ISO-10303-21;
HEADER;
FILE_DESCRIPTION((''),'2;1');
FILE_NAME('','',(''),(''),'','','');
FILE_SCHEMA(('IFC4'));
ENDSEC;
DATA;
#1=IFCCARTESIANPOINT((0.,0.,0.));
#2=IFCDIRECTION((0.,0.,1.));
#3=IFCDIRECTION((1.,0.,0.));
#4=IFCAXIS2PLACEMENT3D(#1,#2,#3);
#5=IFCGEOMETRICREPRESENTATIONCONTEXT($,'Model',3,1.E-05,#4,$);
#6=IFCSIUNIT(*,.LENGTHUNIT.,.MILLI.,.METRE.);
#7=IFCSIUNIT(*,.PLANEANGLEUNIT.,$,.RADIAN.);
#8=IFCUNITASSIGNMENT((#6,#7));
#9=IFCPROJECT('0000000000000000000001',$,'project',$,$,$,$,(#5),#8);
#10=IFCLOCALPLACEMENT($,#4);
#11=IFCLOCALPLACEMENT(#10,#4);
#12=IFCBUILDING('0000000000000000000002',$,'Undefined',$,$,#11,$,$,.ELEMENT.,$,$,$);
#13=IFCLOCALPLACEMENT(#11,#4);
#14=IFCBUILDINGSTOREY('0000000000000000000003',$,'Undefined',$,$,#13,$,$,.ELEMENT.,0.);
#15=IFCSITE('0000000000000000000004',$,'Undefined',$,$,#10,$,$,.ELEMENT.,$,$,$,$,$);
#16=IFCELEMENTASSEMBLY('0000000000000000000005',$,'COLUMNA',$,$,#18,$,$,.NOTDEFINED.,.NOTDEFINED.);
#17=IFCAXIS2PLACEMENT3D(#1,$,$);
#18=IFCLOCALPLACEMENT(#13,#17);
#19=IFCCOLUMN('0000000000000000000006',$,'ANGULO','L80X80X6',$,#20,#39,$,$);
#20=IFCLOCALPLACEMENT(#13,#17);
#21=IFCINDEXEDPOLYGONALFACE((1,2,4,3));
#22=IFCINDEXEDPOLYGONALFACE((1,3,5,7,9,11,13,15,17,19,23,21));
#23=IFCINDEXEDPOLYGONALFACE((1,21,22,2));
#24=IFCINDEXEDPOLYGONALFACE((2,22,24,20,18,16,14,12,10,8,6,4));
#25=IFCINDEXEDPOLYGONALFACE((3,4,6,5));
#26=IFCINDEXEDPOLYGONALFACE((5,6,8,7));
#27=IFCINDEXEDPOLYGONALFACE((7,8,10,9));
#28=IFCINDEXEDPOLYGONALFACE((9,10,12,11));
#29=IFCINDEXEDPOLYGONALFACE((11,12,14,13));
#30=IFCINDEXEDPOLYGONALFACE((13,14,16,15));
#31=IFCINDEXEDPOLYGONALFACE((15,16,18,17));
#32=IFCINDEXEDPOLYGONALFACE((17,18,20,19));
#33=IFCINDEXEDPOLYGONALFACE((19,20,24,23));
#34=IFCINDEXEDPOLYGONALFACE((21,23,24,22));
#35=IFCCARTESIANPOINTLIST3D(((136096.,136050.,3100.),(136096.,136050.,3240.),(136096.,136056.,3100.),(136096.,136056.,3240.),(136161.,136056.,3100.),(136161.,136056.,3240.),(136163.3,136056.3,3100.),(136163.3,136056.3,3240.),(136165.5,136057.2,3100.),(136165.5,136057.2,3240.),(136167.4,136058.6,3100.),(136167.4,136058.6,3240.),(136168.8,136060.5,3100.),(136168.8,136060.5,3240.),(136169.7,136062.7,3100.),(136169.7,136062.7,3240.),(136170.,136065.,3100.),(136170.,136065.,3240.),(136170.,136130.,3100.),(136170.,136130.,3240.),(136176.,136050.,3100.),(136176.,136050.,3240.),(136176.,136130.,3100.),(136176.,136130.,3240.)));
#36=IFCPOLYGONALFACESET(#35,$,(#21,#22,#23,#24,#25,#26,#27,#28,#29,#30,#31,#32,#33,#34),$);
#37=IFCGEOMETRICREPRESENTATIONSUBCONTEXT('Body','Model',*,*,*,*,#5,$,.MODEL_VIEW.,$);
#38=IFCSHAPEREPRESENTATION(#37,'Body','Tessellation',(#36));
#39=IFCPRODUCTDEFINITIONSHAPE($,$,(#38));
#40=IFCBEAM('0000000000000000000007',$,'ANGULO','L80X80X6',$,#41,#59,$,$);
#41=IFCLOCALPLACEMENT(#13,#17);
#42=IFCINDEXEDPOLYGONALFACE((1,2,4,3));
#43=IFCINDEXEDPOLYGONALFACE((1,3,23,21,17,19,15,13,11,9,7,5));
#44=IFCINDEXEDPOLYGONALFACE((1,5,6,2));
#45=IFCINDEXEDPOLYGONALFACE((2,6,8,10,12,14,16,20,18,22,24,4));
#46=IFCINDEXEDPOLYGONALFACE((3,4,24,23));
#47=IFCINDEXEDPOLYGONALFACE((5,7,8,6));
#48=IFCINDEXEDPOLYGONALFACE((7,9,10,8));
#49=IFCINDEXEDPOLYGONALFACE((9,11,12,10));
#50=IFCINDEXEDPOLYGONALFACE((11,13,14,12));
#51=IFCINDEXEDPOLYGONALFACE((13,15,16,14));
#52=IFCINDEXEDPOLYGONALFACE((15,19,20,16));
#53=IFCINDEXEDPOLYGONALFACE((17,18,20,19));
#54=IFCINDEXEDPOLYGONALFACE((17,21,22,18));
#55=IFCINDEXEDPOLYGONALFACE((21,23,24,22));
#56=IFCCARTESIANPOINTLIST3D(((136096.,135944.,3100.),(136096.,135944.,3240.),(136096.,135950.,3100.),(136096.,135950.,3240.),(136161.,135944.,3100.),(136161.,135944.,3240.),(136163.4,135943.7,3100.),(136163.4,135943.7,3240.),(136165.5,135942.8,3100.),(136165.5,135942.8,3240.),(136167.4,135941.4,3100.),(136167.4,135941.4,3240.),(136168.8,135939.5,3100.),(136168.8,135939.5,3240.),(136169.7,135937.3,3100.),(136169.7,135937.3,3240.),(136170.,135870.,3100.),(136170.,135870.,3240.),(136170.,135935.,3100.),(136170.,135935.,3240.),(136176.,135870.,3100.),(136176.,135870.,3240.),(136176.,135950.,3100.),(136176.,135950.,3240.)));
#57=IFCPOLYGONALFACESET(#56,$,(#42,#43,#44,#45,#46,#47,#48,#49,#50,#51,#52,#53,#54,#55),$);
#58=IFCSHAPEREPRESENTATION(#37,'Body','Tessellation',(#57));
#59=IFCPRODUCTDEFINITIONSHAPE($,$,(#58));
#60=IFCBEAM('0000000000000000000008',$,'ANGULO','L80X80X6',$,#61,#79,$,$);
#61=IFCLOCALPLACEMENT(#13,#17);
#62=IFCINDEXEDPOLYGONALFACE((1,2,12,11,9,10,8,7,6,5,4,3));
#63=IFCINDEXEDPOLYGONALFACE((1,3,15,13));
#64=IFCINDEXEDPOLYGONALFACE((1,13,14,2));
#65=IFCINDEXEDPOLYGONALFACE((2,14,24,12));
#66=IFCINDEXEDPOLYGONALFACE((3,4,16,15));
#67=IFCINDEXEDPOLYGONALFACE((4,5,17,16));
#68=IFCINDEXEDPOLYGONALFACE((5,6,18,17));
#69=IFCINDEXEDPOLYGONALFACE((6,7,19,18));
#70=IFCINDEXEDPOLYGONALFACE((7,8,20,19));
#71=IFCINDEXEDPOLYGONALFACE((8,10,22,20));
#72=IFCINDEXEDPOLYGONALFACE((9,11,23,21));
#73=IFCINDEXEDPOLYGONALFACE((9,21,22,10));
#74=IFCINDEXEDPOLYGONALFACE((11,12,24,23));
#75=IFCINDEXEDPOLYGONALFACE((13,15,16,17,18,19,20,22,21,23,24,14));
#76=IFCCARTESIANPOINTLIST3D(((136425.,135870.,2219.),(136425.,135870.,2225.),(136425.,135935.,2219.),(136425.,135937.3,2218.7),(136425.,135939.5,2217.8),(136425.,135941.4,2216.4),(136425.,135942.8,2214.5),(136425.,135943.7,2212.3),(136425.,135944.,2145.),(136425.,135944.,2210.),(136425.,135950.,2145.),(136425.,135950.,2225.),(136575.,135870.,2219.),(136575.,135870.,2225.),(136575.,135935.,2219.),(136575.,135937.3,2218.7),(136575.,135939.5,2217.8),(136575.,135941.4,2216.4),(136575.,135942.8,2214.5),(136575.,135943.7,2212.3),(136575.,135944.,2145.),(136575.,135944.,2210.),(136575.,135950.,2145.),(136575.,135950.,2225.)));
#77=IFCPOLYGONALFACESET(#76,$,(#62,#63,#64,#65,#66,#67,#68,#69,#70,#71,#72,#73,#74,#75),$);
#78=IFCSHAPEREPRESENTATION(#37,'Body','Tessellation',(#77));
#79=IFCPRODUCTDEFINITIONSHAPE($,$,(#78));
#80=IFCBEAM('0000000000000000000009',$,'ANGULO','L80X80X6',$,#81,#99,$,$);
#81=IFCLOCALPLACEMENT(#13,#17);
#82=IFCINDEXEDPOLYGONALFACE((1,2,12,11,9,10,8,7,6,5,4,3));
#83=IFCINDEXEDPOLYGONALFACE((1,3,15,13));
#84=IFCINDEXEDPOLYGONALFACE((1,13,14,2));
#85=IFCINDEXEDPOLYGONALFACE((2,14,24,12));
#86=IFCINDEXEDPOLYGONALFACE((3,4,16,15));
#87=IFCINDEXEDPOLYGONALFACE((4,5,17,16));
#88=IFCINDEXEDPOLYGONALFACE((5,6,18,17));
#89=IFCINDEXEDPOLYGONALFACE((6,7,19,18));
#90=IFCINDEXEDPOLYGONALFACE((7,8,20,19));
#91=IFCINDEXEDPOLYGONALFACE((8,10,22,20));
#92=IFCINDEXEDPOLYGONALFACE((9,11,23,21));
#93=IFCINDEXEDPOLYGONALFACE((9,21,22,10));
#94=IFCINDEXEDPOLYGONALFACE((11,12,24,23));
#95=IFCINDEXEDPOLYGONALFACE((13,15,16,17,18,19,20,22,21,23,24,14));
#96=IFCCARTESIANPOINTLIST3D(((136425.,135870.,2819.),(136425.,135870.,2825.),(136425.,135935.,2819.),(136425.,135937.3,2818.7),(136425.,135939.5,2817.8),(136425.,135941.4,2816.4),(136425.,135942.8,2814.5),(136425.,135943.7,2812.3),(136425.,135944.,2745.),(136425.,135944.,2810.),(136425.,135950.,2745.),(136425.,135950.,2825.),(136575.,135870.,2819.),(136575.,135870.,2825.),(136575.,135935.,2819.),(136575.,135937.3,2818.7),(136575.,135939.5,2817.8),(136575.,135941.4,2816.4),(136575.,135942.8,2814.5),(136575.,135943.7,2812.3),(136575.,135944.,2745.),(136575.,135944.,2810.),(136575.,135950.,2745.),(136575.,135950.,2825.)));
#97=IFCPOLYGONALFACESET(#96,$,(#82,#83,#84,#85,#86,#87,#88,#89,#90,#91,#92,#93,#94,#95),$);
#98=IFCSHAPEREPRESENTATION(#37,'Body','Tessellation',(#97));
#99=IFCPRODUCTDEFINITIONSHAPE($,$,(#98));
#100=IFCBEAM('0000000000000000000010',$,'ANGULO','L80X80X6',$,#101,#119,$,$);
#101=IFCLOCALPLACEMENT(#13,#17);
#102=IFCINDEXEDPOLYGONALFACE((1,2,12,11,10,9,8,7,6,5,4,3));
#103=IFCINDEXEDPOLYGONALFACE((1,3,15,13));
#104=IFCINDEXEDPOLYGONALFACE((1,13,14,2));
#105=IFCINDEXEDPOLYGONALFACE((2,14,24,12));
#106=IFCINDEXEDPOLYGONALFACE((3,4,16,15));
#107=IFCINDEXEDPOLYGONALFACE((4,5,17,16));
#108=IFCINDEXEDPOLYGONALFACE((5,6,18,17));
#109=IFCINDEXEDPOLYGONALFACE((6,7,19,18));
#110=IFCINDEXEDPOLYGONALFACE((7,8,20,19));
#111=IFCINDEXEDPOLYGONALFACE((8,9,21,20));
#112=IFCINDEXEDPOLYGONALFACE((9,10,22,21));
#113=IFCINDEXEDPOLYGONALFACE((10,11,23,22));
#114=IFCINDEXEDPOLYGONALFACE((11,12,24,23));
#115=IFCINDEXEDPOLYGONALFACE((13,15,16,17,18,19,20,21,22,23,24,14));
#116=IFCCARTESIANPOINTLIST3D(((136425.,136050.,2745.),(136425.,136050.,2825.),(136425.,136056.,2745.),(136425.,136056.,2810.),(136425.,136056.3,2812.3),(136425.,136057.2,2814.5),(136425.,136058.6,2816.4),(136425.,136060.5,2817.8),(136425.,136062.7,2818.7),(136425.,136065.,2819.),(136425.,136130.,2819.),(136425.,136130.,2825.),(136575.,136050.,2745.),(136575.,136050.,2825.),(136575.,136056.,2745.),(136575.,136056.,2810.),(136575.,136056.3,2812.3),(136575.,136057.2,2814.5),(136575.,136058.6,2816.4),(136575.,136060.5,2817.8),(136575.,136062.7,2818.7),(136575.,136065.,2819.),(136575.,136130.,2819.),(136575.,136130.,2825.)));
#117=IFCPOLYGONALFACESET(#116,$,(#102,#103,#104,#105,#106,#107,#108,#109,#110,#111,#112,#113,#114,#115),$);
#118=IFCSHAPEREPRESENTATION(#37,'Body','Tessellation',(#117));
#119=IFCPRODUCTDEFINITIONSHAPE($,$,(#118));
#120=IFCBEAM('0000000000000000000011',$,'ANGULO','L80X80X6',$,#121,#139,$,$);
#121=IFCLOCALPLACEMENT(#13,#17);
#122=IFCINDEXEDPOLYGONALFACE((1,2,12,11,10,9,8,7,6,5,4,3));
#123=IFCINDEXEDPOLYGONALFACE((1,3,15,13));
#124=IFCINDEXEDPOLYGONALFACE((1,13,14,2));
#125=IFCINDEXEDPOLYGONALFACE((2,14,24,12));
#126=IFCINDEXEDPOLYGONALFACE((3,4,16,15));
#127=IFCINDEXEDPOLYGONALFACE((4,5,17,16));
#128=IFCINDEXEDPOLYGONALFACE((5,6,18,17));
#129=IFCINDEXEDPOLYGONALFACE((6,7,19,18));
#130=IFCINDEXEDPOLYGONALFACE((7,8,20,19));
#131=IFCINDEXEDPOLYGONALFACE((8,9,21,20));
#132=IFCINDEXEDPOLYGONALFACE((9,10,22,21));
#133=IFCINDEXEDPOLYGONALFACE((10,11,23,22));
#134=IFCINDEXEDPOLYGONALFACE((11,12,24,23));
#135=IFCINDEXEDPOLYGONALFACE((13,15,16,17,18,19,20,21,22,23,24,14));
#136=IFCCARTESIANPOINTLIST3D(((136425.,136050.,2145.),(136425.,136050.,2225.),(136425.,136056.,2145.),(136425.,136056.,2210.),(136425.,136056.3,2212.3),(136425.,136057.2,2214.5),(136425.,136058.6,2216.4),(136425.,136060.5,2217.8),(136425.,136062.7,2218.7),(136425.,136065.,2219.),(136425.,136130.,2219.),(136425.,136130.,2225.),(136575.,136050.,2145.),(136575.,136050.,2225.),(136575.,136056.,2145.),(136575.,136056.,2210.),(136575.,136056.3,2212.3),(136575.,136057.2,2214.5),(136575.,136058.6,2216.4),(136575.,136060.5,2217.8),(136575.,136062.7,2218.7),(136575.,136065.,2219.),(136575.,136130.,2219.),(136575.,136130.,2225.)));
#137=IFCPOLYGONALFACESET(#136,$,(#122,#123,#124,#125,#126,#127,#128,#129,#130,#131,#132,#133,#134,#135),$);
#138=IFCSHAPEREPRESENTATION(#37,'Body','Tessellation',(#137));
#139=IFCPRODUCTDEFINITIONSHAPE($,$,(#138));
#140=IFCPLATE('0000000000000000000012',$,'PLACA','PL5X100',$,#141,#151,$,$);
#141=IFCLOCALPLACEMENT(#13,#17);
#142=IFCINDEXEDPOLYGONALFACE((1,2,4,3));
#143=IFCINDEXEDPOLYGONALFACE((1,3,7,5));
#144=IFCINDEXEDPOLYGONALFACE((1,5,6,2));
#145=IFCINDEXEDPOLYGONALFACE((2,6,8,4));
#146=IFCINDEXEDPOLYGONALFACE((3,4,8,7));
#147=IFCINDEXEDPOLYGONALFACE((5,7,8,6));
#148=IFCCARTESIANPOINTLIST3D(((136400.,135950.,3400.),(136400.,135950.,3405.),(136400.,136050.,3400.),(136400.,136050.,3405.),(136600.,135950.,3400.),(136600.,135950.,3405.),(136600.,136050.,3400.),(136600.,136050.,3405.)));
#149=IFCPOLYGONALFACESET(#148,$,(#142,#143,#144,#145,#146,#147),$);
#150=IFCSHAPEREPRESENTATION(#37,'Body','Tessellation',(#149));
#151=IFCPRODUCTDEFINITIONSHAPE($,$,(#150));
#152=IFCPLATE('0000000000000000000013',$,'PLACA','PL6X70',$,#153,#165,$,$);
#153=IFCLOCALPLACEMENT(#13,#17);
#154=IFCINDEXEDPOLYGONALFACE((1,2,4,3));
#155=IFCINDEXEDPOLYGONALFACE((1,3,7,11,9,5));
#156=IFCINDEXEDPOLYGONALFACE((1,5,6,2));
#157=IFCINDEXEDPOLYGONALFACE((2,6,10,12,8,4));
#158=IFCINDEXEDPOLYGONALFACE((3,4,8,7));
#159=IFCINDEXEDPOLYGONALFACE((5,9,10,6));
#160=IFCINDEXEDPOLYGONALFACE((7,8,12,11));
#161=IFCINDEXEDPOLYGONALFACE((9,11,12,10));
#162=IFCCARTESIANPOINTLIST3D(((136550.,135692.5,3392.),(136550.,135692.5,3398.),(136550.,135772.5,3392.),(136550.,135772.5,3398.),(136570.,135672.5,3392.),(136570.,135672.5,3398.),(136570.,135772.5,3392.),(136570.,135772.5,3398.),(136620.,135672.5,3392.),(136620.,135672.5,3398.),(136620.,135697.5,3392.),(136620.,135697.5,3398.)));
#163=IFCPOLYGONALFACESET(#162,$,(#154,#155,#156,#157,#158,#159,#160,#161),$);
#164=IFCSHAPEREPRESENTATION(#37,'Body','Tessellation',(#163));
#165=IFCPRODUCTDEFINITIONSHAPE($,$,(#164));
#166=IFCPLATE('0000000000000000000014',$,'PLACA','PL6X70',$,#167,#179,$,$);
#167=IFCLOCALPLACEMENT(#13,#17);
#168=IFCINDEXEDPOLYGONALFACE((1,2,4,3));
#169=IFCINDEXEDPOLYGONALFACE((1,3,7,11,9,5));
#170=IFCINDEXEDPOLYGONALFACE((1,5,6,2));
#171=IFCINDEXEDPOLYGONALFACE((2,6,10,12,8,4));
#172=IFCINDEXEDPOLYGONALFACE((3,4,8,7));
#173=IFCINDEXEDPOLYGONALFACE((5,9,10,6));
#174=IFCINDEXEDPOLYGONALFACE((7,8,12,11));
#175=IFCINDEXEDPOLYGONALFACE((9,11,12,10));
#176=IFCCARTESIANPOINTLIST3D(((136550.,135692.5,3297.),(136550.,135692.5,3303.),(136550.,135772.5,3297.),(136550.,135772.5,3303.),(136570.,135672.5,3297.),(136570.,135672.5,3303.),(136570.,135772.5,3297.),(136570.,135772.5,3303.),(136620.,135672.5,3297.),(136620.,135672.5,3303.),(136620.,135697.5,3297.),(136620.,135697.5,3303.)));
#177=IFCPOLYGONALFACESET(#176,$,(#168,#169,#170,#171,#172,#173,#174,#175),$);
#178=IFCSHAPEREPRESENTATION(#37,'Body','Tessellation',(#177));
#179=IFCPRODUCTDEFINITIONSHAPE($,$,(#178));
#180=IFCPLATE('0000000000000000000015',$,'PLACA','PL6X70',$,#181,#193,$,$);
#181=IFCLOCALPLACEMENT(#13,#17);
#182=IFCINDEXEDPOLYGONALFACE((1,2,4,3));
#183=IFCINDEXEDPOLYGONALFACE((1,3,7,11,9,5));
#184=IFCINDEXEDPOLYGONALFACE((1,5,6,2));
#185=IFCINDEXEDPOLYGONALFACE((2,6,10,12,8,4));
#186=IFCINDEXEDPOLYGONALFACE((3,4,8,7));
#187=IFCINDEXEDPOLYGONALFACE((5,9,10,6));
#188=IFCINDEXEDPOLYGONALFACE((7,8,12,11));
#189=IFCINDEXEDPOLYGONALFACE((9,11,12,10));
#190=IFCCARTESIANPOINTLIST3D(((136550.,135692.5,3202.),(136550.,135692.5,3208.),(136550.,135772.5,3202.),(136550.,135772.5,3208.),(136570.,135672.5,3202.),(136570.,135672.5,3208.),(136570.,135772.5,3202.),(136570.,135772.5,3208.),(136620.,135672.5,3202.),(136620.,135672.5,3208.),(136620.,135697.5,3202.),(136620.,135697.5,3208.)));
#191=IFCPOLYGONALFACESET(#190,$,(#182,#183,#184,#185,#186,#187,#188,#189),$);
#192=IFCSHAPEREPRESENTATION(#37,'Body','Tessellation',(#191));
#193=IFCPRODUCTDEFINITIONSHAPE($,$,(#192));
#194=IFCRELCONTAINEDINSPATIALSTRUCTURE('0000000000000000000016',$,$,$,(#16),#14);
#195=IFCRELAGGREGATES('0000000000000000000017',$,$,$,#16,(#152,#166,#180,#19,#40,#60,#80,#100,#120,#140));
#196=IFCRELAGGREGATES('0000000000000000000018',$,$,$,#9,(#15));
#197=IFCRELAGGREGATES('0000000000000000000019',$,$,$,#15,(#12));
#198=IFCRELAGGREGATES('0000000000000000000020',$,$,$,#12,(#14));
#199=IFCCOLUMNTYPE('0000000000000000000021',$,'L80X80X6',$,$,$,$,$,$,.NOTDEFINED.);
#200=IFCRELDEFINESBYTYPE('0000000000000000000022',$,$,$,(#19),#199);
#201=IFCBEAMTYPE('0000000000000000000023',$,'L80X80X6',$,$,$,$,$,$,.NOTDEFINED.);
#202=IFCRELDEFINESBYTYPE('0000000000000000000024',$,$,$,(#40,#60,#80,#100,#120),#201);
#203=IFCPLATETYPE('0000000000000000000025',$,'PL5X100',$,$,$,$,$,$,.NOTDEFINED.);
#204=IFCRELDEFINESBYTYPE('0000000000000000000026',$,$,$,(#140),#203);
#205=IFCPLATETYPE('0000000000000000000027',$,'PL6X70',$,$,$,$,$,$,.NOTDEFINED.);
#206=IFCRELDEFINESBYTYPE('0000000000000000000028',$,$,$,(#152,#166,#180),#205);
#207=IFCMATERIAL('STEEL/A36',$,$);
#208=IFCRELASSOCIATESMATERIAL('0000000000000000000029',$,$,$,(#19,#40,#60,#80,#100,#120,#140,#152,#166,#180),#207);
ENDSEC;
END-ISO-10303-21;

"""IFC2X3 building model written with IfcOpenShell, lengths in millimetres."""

from ifc_helpers import new_model, si_unit, frame, origin_with_axes, origin_2d_with_axis, place, context, subcontext, project, spatial, polyline, l_section, outline, extrude, material, type_object, element, aggregate, save


model = new_model("IFC2X3")

# Units and contexts
model_context = context("Model", 3, precision=1e-05, world=origin_with_axes())
body_context = subcontext(model_context, "Body", "Model", "MODEL_VIEW")
ifc_project = project(units=[si_unit("LENGTHUNIT", "METRE", prefix="MILLI"), si_unit("PLANEANGLEUNIT", "RADIAN")], contexts=[model_context])

# Site, building, storey
site_placement = place(None, origin_with_axes())
site = spatial("IfcSite", under=ifc_project, at=site_placement, Name="Undefined", CompositionType="ELEMENT")
building_placement = place(site_placement, origin_with_axes())
building = spatial("IfcBuilding", under=site, at=building_placement, Name="Undefined", CompositionType="ELEMENT")
storey_placement = place(building_placement, origin_with_axes())
storey = spatial("IfcBuildingStorey", under=building, at=storey_placement, Name="Undefined", CompositionType="ELEMENT", Elevation=0.0)

# Element assembly, column, beams
assembly_1_placement = place(storey_placement, origin_with_axes())
assembly_1 = element("IfcElementAssembly", 1, at=assembly_1_placement, inside=storey, Name="COLUMNA", AssemblyPlace="NOTDEFINED", PredefinedType="NOTDEFINED")
ifc_material_1 = material(Name="STEEL/A36")
column_type = type_object("IfcColumnType", Name="L80X80X6", PredefinedType="NOTDEFINED")
column_placement = place(assembly_1_placement, frame((136136.0, 136090.0, 3100.0), z_axis=(0.0, 0.0, 1.0), x_axis=(0.0, 1.0, 0.0)))
column = element("IfcColumn", 2, at=column_placement, type_object=column_type, material=ifc_material_1, Name="ANGULO", Description="L80X80X6", context=body_context, shape_type="SweptSolid", body=[
    extrude(l_section(Depth=80.0, Width=80.0, Thickness=6.0, FilletRadius=9.0, at=origin_2d_with_axis()), frame((0.0, 0.0, 140.0), z_axis=(0.0, 0.0, -1.0), x_axis=(0.0, 1.0, 0.0)), (0.0, 0.0, 1.0), 140.0),
])
beam_type_1 = type_object("IfcBeamType", Name="L80X80X6", PredefinedType="NOTDEFINED")
beam_1_placement = place(assembly_1_placement, frame((136136.0, 135910.0, 3240.0), z_axis=(0.0, -1.0, 0.0), x_axis=(0.0, 0.0, -1.0)))
beam_1 = element("IfcBeam", 3, at=beam_1_placement, type_object=beam_type_1, material=ifc_material_1, Name="ANGULO", Description="L80X80X6", context=body_context, shape_type="SweptSolid", body=[
    extrude(l_section(Depth=80.0, Width=80.0, Thickness=6.0, FilletRadius=9.0, at=origin_2d_with_axis()), frame((140.0, 0.0, 0.0), z_axis=(-1.0, 0.0, 0.0), x_axis=(0.0, -1.0, 0.0)), (0.0, 0.0, 1.0), 140.0),
])
beam_2_placement = place(assembly_1_placement, frame((136425.0, 135910.0, 2185.0), z_axis=(0.0, -1.0, 0.0), x_axis=(1.0, 0.0, 0.0)))
beam_2 = element("IfcBeam", 4, at=beam_2_placement, type_object=beam_type_1, material=ifc_material_1, Name="ANGULO", Description="L80X80X6", context=body_context, shape_type="SweptSolid", body=[
    extrude(l_section(Depth=80.0, Width=80.0, Thickness=6.0, FilletRadius=9.0, at=origin_2d_with_axis()), frame((150.0, 0.0, 0.0), z_axis=(-1.0, 0.0, 0.0), x_axis=(0.0, -1.0, 0.0)), (0.0, 0.0, 1.0), 150.0),
])
beam_3_placement = place(assembly_1_placement, frame((136425.0, 135910.0, 2785.0), z_axis=(0.0, -1.0, 0.0), x_axis=(1.0, 0.0, 0.0)))
beam_3 = element("IfcBeam", 5, at=beam_3_placement, type_object=beam_type_1, material=ifc_material_1, Name="ANGULO", Description="L80X80X6", context=body_context, shape_type="SweptSolid", body=[
    extrude(l_section(Depth=80.0, Width=80.0, Thickness=6.0, FilletRadius=9.0, at=origin_2d_with_axis()), frame((150.0, 0.0, 0.0), z_axis=(-1.0, 0.0, 0.0), x_axis=(0.0, -1.0, 0.0)), (0.0, 0.0, 1.0), 150.0),
])
beam_4_placement = place(assembly_1_placement, frame((136575.0, 136090.0, 2785.0), z_axis=(0.0, 1.0, 0.0), x_axis=(-1.0, 0.0, 0.0)))
beam_4 = element("IfcBeam", 6, at=beam_4_placement, type_object=beam_type_1, material=ifc_material_1, Name="ANGULO", Description="L80X80X6", context=body_context, shape_type="SweptSolid", body=[
    extrude(l_section(Depth=80.0, Width=80.0, Thickness=6.0, FilletRadius=9.0, at=origin_2d_with_axis()), frame((150.0, 0.0, 0.0), z_axis=(-1.0, 0.0, 0.0), x_axis=(0.0, -1.0, 0.0)), (0.0, 0.0, 1.0), 150.0),
])
beam_5_placement = place(assembly_1_placement, frame((136575.0, 136090.0, 2185.0), z_axis=(0.0, 1.0, 0.0), x_axis=(-1.0, 0.0, 0.0)))
beam_5 = element("IfcBeam", 7, at=beam_5_placement, type_object=beam_type_1, material=ifc_material_1, Name="ANGULO", Description="L80X80X6", context=body_context, shape_type="SweptSolid", body=[
    extrude(l_section(Depth=80.0, Width=80.0, Thickness=6.0, FilletRadius=9.0, at=origin_2d_with_axis()), frame((150.0, 0.0, 0.0), z_axis=(-1.0, 0.0, 0.0), x_axis=(0.0, -1.0, 0.0)), (0.0, 0.0, 1.0), 150.0),
])

# Plates
plate_type_1 = type_object("IfcPlateType", Name="PL5X100", PredefinedType="NOTDEFINED")
plate_1_placement = place(assembly_1_placement, frame((136600.0, 136050.0, 3402.5), z_axis=(0.0, 0.0, -1.0), x_axis=(0.0, -1.0, 0.0)))
plate_1 = element("IfcPlate", 8, at=plate_1_placement, type_object=plate_type_1, material=ifc_material_1, Name="PLACA", Description="PL5X100", context=body_context, shape_type="SweptSolid", body=[
    extrude(outline(polyline([(0.0, 0.0), (100.0, 0.0), (100.0, 200.0), (0.0, 200.0), (0.0, 0.0)])), frame((0.0, 0.0, -2.5), z_axis=(0.0, 0.0, 1.0), x_axis=(1.0, 0.0, 0.0)), (0.0, 0.0, 1.0), 5.0),
])
plate_type_2 = type_object("IfcPlateType", Name="PL6X70", PredefinedType="NOTDEFINED")
plate_2_placement = place(assembly_1_placement, frame((136620.0, 135672.5, 3395.0), z_axis=(0.0, 0.0, 1.0), x_axis=(0.0, 1.0, 0.0)))
plate_2 = element("IfcPlate", 9, at=plate_2_placement, type_object=plate_type_2, material=ifc_material_1, Name="PLACA", Description="PL6X70", context=body_context, shape_type="SweptSolid", body=[
    extrude(outline(polyline([(0.0, 0.0), (25.0, 0.0), (100.0, 50.0), (100.0, 70.0), (20.0, 70.0), (0.0, 50.0), (0.0, 0.0)])), frame((0.0, 0.0, -3.0), z_axis=(0.0, 0.0, 1.0), x_axis=(1.0, 0.0, 0.0)), (0.0, 0.0, 1.0), 6.0),
])
plate_3_placement = place(assembly_1_placement, frame((136620.0, 135672.5, 3300.0), z_axis=(0.0, 0.0, 1.0), x_axis=(0.0, 1.0, 0.0)))
plate_3 = element("IfcPlate", 10, at=plate_3_placement, type_object=plate_type_2, material=ifc_material_1, Name="PLACA", Description="PL6X70", context=body_context, shape_type="SweptSolid", body=[
    extrude(outline(polyline([(0.0, 0.0), (25.0, 0.0), (100.0, 50.0), (100.0, 70.0), (20.0, 70.0), (0.0, 50.0), (0.0, 0.0)])), frame((0.0, 0.0, -3.0), z_axis=(0.0, 0.0, 1.0), x_axis=(1.0, 0.0, 0.0)), (0.0, 0.0, 1.0), 6.0),
])
plate_4_placement = place(assembly_1_placement, frame((136620.0, 135672.5, 3205.0), z_axis=(0.0, 0.0, 1.0), x_axis=(0.0, 1.0, 0.0)))
plate_4 = element("IfcPlate", 11, at=plate_4_placement, type_object=plate_type_2, material=ifc_material_1, Name="PLACA", Description="PL6X70", context=body_context, shape_type="SweptSolid", body=[
    extrude(outline(polyline([(0.0, 0.0), (25.0, 0.0), (100.0, 50.0), (100.0, 70.0), (20.0, 70.0), (0.0, 50.0), (0.0, 0.0)])), frame((0.0, 0.0, -3.0), z_axis=(0.0, 0.0, 1.0), x_axis=(1.0, 0.0, 0.0)), (0.0, 0.0, 1.0), 6.0),
])

aggregate(assembly_1, [plate_2, plate_3, plate_4, column, beam_1, beam_2, beam_3, beam_4, beam_5, plate_1])

save(model, "model.ifc")
